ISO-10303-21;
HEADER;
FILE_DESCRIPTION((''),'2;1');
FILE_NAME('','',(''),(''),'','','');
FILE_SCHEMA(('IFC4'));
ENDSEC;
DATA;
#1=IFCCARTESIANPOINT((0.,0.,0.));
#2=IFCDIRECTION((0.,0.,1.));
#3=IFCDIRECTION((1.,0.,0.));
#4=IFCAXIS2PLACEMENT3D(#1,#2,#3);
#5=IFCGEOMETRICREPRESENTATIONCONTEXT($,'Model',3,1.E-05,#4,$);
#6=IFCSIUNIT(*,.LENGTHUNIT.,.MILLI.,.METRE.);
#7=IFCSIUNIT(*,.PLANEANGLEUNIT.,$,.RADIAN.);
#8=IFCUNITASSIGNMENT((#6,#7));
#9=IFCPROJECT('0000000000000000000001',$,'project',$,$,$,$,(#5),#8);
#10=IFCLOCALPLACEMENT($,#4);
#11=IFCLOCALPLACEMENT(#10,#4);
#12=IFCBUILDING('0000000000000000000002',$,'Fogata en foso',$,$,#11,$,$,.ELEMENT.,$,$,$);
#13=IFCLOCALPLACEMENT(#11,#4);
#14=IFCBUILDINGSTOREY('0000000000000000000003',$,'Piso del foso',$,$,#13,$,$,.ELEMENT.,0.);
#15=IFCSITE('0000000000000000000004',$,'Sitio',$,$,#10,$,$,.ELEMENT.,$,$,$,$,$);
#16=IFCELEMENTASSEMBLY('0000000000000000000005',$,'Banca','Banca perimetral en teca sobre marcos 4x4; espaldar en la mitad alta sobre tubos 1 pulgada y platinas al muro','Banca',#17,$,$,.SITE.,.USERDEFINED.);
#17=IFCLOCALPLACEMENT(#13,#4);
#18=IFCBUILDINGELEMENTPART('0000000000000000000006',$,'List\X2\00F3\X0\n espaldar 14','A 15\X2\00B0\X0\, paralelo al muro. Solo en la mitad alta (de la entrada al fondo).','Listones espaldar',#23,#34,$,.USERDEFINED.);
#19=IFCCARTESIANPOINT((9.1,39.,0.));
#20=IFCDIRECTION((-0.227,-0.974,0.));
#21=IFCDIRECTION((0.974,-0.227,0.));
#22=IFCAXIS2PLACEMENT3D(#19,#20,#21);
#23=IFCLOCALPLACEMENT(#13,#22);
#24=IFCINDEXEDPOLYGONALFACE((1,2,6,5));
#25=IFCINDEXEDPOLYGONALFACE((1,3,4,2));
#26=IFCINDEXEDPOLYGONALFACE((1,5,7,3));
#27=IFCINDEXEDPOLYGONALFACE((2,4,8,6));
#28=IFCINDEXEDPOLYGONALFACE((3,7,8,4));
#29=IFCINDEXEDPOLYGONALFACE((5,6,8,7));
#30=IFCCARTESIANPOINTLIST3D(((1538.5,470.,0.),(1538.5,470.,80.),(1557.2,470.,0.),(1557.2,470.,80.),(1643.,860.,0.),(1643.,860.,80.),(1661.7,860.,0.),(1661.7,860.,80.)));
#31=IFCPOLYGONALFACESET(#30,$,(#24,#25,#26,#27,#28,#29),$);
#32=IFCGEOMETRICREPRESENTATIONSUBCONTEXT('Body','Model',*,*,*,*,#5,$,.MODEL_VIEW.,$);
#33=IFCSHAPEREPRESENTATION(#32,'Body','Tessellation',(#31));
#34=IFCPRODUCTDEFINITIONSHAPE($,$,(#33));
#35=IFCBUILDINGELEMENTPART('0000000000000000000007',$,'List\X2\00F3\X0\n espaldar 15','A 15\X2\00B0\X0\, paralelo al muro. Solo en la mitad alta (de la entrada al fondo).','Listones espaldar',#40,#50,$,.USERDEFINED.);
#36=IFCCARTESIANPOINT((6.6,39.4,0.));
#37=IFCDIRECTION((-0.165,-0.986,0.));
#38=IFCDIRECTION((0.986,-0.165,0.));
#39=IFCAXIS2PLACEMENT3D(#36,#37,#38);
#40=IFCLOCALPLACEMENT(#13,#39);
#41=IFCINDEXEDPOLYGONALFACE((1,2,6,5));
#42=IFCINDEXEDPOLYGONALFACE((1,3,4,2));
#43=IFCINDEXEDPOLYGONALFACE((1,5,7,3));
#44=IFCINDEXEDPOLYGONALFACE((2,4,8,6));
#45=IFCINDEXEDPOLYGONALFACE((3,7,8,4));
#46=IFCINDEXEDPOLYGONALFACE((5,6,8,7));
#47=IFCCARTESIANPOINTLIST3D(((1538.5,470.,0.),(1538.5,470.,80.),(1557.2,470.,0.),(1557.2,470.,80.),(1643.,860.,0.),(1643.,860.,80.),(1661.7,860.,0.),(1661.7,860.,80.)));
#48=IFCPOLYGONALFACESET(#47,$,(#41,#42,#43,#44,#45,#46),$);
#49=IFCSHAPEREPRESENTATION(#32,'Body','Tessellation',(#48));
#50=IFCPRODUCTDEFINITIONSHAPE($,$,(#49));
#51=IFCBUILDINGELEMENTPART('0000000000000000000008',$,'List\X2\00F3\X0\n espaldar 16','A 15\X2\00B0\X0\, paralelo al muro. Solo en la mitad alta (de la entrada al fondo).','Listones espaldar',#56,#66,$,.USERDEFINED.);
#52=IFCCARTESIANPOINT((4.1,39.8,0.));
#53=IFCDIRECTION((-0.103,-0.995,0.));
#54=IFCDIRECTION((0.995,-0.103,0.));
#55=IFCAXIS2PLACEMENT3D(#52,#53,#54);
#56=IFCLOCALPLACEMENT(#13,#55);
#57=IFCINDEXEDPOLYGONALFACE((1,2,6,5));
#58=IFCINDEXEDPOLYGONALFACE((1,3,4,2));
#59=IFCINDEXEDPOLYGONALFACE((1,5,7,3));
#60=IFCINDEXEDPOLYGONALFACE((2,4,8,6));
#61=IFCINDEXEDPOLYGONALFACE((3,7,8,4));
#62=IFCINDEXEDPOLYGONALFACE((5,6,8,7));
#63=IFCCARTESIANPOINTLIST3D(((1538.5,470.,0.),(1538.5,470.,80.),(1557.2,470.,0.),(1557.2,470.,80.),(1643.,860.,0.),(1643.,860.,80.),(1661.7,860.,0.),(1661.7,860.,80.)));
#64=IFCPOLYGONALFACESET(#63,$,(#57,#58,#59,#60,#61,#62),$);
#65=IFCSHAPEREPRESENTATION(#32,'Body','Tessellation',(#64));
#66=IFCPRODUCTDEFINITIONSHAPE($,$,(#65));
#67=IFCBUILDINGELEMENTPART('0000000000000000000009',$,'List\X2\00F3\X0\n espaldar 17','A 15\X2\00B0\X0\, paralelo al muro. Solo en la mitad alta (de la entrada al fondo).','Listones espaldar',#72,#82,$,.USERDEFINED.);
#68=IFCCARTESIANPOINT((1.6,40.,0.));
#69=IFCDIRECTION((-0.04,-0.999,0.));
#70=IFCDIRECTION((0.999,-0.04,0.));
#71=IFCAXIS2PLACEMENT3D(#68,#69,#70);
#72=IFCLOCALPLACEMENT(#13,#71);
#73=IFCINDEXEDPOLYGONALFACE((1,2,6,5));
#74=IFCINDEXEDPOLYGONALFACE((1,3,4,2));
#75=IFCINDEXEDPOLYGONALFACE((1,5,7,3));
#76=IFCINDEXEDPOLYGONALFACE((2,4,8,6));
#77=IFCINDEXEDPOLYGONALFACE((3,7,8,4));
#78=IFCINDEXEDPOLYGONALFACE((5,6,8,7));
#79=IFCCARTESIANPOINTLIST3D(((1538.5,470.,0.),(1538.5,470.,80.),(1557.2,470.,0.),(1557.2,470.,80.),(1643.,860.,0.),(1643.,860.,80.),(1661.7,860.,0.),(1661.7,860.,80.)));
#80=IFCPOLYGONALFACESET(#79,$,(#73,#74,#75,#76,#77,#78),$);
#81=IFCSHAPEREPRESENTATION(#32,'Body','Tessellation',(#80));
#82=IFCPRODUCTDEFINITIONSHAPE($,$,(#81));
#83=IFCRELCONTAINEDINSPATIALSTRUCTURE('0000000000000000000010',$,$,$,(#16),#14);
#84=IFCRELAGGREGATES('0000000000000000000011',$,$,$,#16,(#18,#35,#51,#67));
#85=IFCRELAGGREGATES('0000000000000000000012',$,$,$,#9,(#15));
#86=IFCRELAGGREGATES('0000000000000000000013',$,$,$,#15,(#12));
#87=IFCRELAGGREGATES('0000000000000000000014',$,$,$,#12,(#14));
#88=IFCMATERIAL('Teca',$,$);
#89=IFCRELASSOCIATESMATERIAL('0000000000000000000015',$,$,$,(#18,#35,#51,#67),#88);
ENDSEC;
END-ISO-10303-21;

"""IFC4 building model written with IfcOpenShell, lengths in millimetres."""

from ifc_helpers import new_model, si_unit, frame, origin_with_axes, place, context, subcontext, project, spatial, polyline, outline, extrude, material, element, aggregate, save


model = new_model("IFC4")

# Units and contexts
model_context = context("Model", 3, precision=1e-05, world=origin_with_axes())
body_context = subcontext(model_context, "Body", "Model", "MODEL_VIEW")
ifc_project = project(units=[si_unit("LENGTHUNIT", "METRE", prefix="MILLI"), si_unit("PLANEANGLEUNIT", "RADIAN")], contexts=[model_context])

# Site, building, storey
site_placement = place(None, origin_with_axes())
site = spatial("IfcSite", under=ifc_project, at=site_placement, Name="Sitio", CompositionType="ELEMENT")
building_placement = place(site_placement, origin_with_axes())
building = spatial("IfcBuilding", under=site, at=building_placement, Name="Fogata en foso", CompositionType="ELEMENT")
storey_placement = place(building_placement, origin_with_axes())
storey = spatial("IfcBuildingStorey", under=building, at=storey_placement, Name="Piso del foso", CompositionType="ELEMENT", Elevation=0.0)

# Element assembly, building element parts
assembly_1_placement = place(storey_placement, origin_with_axes())
assembly_1 = element("IfcElementAssembly", 1, at=assembly_1_placement, inside=storey, Name="Banca", Description="Banca perimetral en teca sobre marcos 4x4; espaldar en la mitad alta sobre tubos 1 pulgada y platinas al muro", ObjectType="Banca", AssemblyPlace="SITE", PredefinedType="USERDEFINED")
ifc_material = material(Name="Teca")
building_element_part_1_placement = place(storey_placement, frame((9.1, 39.0, 0.0), z_axis=(-0.227, -0.974, 0.0), x_axis=(0.974, -0.227, 0.0)))
building_element_part_1 = element("IfcBuildingElementPart", 2, at=building_element_part_1_placement, material=ifc_material, Name="Listón espaldar 14", Description="A 15°, paralelo al muro. Solo en la mitad alta (de la entrada al fondo).", ObjectType="Listones espaldar", PredefinedType="USERDEFINED", context=body_context, shape_type="SweptSolid", body=[
    extrude(outline(polyline([(1538.5, 470.0), (1557.2, 470.0), (1661.7, 860.0), (1643.0, 860.0), (1538.5, 470.0)])), origin_with_axes(), (0.0, 0.0, 1.0), 80.0),
])
building_element_part_2_placement = place(storey_placement, frame((6.6, 39.4, 0.0), z_axis=(-0.165, -0.986, 0.0), x_axis=(0.986, -0.165, 0.0)))
building_element_part_2 = element("IfcBuildingElementPart", 3, at=building_element_part_2_placement, material=ifc_material, Name="Listón espaldar 15", Description="A 15°, paralelo al muro. Solo en la mitad alta (de la entrada al fondo).", ObjectType="Listones espaldar", PredefinedType="USERDEFINED", context=body_context, shape_type="SweptSolid", body=[
    extrude(outline(polyline([(1538.5, 470.0), (1557.2, 470.0), (1661.7, 860.0), (1643.0, 860.0), (1538.5, 470.0)])), origin_with_axes(), (0.0, 0.0, 1.0), 80.0),
])
building_element_part_3_placement = place(storey_placement, frame((4.1, 39.8, 0.0), z_axis=(-0.103, -0.995, 0.0), x_axis=(0.995, -0.103, 0.0)))
building_element_part_3 = element("IfcBuildingElementPart", 4, at=building_element_part_3_placement, material=ifc_material, Name="Listón espaldar 16", Description="A 15°, paralelo al muro. Solo en la mitad alta (de la entrada al fondo).", ObjectType="Listones espaldar", PredefinedType="USERDEFINED", context=body_context, shape_type="SweptSolid", body=[
    extrude(outline(polyline([(1538.5, 470.0), (1557.2, 470.0), (1661.7, 860.0), (1643.0, 860.0), (1538.5, 470.0)])), origin_with_axes(), (0.0, 0.0, 1.0), 80.0),
])
building_element_part_4_placement = place(storey_placement, frame((1.6, 40.0, 0.0), z_axis=(-0.04, -0.999, 0.0), x_axis=(0.999, -0.04, 0.0)))
building_element_part_4 = element("IfcBuildingElementPart", 5, at=building_element_part_4_placement, material=ifc_material, Name="Listón espaldar 17", Description="A 15°, paralelo al muro. Solo en la mitad alta (de la entrada al fondo).", ObjectType="Listones espaldar", PredefinedType="USERDEFINED", context=body_context, shape_type="SweptSolid", body=[
    extrude(outline(polyline([(1538.5, 470.0), (1557.2, 470.0), (1661.7, 860.0), (1643.0, 860.0), (1538.5, 470.0)])), origin_with_axes(), (0.0, 0.0, 1.0), 80.0),
])
aggregate(assembly_1, [building_element_part_1, building_element_part_2, building_element_part_3, building_element_part_4])

save(model, "model.ifc")
